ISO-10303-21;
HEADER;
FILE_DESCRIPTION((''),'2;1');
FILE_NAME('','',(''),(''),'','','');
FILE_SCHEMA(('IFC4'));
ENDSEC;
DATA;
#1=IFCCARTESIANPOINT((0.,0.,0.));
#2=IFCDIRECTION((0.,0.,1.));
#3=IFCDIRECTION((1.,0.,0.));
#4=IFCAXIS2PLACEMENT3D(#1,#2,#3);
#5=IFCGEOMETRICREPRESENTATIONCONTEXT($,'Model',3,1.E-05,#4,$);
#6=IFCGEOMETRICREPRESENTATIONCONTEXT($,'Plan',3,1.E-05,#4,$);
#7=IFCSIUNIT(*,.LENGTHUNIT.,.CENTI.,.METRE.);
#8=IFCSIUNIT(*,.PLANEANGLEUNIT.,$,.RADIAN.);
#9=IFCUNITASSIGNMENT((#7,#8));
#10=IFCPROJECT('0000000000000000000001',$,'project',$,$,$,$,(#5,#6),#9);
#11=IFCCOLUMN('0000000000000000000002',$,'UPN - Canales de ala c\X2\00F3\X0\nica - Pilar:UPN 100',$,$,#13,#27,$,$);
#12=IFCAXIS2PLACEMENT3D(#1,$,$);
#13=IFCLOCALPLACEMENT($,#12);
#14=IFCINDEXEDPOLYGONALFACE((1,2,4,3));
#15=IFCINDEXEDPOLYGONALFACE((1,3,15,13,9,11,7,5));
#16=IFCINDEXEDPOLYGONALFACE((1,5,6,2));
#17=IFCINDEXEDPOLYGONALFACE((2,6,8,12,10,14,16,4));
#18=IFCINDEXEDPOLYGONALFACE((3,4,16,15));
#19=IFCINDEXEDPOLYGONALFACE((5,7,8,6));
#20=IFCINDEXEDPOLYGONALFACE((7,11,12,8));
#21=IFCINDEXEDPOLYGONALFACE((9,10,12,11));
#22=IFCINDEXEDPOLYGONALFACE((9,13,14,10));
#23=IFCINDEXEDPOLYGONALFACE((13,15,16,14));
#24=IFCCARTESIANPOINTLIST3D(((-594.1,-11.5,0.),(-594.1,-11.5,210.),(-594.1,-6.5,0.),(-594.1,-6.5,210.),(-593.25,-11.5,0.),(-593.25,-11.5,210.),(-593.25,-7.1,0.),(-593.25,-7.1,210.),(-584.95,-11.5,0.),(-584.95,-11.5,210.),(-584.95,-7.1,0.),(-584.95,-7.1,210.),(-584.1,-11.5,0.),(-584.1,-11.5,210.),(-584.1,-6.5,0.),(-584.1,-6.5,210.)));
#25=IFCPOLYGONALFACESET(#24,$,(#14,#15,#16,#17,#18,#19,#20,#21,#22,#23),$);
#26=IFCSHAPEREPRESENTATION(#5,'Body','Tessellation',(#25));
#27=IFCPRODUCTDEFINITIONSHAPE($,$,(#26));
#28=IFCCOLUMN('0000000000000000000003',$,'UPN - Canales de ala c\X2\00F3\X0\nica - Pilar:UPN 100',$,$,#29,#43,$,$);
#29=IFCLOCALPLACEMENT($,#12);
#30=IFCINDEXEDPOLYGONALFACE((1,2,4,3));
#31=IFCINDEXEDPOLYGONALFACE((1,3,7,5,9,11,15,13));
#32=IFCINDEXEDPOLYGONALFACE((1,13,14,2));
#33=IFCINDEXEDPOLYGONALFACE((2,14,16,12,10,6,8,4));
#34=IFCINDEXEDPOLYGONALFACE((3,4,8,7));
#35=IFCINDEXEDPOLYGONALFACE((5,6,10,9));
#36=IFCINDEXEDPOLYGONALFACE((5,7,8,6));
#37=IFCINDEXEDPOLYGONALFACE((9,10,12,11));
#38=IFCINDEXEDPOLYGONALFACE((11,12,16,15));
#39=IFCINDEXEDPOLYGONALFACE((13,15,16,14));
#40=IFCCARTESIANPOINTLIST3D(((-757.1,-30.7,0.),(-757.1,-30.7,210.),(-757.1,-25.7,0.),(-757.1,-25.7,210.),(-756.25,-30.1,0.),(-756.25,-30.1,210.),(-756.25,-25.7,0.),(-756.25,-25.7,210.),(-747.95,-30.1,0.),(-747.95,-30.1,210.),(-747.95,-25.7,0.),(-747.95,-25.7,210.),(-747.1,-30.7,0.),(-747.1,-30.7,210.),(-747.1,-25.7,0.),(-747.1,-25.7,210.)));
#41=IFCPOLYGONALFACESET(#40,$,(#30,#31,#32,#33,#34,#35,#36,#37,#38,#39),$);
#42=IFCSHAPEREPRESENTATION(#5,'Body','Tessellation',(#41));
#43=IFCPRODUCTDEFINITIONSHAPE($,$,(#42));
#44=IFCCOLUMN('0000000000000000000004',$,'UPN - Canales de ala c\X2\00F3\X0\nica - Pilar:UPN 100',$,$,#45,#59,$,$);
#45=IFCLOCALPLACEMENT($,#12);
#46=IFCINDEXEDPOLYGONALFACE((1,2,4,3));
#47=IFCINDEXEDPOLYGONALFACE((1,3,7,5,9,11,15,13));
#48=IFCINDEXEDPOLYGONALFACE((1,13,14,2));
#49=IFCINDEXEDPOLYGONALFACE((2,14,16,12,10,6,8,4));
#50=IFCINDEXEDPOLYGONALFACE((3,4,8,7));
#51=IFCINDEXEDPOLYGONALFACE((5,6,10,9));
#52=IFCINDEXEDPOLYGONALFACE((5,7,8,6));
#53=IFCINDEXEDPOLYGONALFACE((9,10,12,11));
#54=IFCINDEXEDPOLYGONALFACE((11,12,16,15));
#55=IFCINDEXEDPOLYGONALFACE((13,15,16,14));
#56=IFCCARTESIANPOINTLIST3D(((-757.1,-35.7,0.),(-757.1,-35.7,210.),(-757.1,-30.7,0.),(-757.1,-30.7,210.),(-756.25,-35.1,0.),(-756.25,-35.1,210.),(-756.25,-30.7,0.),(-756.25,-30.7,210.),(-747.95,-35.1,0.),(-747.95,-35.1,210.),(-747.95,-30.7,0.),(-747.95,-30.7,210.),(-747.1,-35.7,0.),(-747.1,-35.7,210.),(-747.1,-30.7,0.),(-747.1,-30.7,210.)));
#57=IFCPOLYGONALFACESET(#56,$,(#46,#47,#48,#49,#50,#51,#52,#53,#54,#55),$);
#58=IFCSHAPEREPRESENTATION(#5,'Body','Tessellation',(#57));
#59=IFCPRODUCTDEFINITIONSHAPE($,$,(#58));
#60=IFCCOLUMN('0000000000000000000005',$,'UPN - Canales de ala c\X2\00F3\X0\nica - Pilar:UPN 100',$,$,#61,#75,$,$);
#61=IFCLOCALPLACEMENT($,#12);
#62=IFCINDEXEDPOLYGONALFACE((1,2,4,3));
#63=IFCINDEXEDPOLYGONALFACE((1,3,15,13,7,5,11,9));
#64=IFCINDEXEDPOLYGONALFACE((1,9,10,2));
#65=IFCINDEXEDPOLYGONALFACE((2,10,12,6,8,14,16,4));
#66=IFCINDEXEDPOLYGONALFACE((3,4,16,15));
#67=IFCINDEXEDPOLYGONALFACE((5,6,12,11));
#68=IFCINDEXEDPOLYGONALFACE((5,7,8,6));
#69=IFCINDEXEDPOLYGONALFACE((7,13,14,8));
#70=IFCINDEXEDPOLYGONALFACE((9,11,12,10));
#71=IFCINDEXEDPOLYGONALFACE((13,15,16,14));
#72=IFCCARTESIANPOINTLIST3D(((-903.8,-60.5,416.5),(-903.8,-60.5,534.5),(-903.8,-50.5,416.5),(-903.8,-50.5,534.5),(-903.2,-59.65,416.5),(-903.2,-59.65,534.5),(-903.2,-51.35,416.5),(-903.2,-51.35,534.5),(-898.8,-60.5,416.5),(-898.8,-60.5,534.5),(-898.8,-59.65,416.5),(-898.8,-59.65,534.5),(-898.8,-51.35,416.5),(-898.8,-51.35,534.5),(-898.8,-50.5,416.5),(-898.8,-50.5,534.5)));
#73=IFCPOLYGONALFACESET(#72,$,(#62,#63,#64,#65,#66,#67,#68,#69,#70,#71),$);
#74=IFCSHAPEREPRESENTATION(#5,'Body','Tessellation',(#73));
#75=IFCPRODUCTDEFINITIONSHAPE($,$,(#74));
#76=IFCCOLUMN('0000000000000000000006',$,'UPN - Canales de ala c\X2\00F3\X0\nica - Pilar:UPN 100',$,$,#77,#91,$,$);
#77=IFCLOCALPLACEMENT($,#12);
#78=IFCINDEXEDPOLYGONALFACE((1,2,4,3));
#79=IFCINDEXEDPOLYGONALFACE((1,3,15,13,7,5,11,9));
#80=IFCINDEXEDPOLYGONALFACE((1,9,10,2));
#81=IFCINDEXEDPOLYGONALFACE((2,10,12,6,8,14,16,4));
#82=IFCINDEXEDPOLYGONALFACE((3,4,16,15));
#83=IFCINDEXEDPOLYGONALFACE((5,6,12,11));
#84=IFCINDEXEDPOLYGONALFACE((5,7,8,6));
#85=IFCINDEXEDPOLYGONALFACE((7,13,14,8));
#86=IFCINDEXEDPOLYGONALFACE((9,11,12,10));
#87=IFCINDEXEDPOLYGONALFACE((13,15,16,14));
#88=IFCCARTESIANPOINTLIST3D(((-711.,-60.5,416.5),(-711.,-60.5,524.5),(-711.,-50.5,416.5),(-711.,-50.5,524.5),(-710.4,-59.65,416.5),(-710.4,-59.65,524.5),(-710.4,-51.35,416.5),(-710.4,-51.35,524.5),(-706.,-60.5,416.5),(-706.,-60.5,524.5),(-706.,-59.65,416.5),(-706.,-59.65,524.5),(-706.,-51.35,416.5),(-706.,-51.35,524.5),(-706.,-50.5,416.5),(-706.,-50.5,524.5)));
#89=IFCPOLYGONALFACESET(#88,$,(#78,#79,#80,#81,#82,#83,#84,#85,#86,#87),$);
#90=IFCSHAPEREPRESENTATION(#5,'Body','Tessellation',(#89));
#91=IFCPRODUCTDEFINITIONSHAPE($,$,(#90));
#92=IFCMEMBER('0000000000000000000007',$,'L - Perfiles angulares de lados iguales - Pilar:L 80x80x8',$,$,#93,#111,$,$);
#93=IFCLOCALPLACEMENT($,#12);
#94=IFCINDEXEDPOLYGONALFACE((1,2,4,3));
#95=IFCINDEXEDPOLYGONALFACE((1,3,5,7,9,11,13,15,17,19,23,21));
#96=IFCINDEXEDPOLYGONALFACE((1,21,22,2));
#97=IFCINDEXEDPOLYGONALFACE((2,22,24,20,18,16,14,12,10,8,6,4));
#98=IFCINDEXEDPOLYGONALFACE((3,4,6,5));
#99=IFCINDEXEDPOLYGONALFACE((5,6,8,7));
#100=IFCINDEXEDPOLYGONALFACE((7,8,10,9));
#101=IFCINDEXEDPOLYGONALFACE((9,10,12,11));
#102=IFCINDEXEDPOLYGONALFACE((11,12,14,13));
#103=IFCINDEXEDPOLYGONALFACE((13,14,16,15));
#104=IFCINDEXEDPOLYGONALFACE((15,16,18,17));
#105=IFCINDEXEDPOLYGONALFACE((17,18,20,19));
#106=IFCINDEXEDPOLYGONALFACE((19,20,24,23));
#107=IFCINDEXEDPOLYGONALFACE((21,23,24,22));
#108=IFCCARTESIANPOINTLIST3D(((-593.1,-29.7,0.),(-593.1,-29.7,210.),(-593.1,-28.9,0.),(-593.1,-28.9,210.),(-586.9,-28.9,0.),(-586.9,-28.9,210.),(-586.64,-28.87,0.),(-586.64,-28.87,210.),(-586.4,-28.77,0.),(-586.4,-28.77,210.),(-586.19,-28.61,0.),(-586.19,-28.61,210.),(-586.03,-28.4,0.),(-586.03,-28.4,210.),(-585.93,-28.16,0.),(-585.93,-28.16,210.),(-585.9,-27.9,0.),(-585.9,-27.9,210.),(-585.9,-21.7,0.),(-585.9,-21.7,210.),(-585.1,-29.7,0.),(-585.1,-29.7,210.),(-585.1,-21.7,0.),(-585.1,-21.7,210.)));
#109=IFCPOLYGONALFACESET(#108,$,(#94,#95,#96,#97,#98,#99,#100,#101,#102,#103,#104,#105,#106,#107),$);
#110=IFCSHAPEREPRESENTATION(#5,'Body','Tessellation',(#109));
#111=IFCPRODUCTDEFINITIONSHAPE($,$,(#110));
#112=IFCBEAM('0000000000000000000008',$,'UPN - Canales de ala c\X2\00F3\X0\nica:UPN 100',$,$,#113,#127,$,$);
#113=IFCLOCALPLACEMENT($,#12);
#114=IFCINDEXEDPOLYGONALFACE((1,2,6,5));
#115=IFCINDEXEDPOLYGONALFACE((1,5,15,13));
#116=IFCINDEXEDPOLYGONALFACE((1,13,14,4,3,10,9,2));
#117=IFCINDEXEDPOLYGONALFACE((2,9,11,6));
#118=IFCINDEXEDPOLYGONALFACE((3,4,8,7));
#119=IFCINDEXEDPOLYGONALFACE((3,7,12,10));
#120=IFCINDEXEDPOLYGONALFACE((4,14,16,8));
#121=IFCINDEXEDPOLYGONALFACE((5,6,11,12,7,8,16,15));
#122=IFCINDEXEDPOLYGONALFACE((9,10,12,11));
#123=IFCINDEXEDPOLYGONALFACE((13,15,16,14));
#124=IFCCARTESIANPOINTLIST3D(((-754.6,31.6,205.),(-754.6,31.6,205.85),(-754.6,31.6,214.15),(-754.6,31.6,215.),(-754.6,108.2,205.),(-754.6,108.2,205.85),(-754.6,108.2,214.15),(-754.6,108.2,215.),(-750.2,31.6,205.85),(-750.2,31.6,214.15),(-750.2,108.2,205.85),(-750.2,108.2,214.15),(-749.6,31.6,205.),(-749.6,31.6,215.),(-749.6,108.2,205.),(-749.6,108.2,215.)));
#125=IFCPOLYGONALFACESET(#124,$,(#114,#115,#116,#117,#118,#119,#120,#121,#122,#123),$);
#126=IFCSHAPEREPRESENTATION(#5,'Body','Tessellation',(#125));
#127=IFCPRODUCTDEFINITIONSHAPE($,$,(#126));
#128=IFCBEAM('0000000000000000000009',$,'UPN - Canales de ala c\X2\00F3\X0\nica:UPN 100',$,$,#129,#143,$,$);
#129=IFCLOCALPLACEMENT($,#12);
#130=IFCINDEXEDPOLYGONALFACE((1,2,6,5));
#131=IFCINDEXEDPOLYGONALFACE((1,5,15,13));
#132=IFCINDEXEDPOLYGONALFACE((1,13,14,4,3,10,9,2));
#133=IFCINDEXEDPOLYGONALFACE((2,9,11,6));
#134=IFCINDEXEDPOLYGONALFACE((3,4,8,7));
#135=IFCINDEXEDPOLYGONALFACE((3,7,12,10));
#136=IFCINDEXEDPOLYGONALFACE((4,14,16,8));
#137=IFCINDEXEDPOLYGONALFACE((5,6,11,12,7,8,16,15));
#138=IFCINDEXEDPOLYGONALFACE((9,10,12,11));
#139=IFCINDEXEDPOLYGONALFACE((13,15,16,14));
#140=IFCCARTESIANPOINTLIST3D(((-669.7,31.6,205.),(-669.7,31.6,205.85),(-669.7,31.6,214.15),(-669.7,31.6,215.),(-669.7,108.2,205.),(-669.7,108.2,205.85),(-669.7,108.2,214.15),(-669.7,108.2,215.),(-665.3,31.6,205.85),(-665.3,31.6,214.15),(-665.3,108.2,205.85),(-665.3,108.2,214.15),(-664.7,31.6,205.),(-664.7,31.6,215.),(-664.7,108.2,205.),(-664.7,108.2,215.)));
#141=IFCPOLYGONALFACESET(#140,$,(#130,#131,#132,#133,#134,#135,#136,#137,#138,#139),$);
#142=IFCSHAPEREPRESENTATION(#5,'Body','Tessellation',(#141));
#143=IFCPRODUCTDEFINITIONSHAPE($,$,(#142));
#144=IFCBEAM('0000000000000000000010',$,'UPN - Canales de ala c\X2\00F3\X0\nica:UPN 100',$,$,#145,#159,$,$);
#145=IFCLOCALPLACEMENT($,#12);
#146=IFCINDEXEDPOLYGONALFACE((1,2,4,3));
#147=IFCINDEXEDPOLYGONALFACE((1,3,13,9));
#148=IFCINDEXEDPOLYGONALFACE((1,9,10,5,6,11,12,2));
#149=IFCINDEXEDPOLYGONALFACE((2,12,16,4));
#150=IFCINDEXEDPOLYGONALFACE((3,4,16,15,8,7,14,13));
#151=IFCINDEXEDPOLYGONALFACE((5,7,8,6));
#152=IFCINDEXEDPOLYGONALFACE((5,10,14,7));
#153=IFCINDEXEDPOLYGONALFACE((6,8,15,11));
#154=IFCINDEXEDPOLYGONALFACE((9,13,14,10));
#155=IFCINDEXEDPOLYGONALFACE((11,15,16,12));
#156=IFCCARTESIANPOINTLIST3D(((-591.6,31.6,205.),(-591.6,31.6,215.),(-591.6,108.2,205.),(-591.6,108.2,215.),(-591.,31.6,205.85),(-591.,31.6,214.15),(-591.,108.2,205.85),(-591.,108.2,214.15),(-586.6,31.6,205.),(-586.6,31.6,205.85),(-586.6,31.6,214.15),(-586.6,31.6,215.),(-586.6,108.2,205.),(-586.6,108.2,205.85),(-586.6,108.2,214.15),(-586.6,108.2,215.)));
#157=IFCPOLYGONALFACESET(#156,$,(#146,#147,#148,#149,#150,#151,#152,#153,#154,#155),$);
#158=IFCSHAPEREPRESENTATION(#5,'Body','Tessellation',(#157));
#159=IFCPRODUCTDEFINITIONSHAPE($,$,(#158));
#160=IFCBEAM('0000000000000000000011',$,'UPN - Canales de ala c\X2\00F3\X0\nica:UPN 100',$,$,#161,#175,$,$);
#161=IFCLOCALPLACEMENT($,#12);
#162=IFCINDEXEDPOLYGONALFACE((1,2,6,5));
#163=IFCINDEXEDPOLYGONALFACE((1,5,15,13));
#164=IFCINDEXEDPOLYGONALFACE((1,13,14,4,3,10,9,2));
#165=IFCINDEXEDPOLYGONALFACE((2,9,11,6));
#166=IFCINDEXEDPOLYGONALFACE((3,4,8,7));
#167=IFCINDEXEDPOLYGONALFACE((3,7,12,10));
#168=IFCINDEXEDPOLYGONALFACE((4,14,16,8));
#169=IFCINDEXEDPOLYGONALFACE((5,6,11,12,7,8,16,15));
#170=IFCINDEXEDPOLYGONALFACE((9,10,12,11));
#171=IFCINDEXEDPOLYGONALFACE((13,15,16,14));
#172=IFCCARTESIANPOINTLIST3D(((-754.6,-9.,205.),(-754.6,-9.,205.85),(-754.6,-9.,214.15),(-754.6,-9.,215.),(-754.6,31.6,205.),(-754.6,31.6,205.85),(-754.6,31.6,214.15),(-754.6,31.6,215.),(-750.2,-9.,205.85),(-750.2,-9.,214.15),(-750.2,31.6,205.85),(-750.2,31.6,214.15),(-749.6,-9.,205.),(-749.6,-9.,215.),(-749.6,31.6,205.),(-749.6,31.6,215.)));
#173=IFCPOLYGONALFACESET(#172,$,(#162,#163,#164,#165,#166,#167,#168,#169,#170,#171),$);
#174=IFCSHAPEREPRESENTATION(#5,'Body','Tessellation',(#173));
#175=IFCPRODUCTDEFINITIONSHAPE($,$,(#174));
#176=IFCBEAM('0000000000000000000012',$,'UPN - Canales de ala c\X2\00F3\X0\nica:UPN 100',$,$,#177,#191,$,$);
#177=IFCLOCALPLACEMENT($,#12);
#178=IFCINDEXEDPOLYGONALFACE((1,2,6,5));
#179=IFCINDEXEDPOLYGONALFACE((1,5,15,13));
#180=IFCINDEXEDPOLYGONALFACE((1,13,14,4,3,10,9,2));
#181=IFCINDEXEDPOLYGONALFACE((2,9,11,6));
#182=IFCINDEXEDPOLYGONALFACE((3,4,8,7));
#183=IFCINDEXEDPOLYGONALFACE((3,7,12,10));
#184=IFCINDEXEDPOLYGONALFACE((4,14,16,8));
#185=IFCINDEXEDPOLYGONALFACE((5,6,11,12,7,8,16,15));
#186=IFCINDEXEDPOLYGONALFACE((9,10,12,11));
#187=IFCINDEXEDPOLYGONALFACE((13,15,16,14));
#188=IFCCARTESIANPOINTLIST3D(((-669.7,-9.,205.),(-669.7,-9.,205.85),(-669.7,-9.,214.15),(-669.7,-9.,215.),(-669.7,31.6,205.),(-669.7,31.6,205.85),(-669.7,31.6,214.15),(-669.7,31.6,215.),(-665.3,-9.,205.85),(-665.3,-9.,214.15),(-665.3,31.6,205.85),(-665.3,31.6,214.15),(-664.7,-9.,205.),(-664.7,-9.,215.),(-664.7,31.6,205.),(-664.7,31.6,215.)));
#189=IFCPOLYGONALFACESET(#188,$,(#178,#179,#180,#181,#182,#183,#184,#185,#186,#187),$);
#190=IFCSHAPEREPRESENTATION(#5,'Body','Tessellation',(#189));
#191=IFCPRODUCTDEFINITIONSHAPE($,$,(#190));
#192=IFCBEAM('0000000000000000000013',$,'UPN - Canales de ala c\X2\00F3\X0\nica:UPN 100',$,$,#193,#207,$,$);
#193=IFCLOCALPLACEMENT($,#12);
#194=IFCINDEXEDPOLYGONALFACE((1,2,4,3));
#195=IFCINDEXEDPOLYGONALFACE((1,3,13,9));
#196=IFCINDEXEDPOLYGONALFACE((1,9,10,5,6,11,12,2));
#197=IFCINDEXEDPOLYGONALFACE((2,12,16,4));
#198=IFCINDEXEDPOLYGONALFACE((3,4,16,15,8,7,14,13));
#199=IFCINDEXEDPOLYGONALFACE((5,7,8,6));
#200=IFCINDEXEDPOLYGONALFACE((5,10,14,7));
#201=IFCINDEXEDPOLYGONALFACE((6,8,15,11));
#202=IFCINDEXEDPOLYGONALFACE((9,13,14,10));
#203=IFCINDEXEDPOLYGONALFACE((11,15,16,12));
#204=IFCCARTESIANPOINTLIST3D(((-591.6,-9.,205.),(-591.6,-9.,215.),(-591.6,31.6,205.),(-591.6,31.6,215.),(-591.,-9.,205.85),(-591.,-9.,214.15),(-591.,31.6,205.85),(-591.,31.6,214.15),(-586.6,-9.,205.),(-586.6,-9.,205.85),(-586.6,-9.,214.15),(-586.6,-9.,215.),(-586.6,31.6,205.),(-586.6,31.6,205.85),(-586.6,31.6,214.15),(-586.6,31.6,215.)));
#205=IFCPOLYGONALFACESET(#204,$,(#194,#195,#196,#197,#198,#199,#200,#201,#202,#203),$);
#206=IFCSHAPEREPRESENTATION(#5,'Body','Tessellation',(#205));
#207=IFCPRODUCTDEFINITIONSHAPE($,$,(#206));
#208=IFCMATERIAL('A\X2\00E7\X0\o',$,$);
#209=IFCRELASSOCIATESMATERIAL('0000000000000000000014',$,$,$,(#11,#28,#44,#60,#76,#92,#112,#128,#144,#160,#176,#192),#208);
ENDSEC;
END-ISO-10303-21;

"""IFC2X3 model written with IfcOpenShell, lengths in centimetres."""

from ifc_helpers import new_model, si_unit, frame, frame_2d, origin_with_axes, origin_2d_with_axis, place, context, project, l_section, u_section, extrude, material, element, save


model = new_model("IFC2X3")

# Units and contexts
model_context = context("Model", 3, precision=1e-05, world=origin_with_axes())
plan_context = context("Plan", 3, precision=1e-05, world=origin_with_axes())
ifc_project = project(units=[si_unit("LENGTHUNIT", "METRE", prefix="CENTI"), si_unit("PLANEANGLEUNIT", "RADIAN")], contexts=[model_context, plan_context])

# Columns
ifc_material = material(Name="Aço")
column_1_placement = place(None, frame((-589.1, -9.0, 0.0), z_axis=(0.0, 0.0, 1.0), x_axis=(0.0, -1.0, 0.0)))
element("IfcColumn", 1, at=column_1_placement, material=ifc_material, Name="UPN - Canales de ala cónica - Pilar:UPN 100", context=model_context, shape_type="SweptSolid", body=[
    extrude(u_section(Depth=10.0, FlangeWidth=5.0, WebThickness=0.6, FlangeThickness=0.85, FilletRadius=0.0, EdgeRadius=0.0, FlangeSlope=0.0, CentreOfGravityInX=0.0, at=frame_2d((0.0, 0.0), x_axis=(1.0, 0.0))), origin_with_axes(), (0.0, 0.0, 1.0), 210.0),
])
for number, where, z_axis, x_axis, name in (
    (2, (-752.1, -28.2, 0.0), (0.0, 0.0, 1.0), (0.0, 1.0, 0.0), "UPN - Canales de ala cónica - Pilar:UPN 100"),
    (3, (-752.1, -33.2, 0.0), (0.0, 0.0, 1.0), (0.0, 1.0, 0.0), "UPN - Canales de ala cónica - Pilar:UPN 100"),
):
    element("IfcColumn", number, at=place(None, frame(where, z_axis=z_axis, x_axis=x_axis)), material=ifc_material, Name=name, context=model_context, shape_type="SweptSolid", body=[
        extrude(u_section(Depth=10.0, FlangeWidth=5.0, WebThickness=0.6, FlangeThickness=0.85, FilletRadius=0.0, EdgeRadius=0.0, FlangeSlope=0.0, CentreOfGravityInX=0.0, at=origin_2d_with_axis()), origin_with_axes(), (0.0, 0.0, 1.0), 210.0),
    ])
column_2_placement = place(None, frame((-901.3, -55.5, 416.5), z_axis=(0.0, 0.0, 1.0), x_axis=(1.0, 0.0, 0.0)))
element("IfcColumn", 4, at=column_2_placement, material=ifc_material, Name="UPN - Canales de ala cónica - Pilar:UPN 100", context=model_context, shape_type="SweptSolid", body=[
    extrude(u_section(Depth=10.0, FlangeWidth=5.0, WebThickness=0.6, FlangeThickness=0.85, FilletRadius=0.0, EdgeRadius=0.0, FlangeSlope=0.0, CentreOfGravityInX=0.0, at=origin_2d_with_axis()), origin_with_axes(), (0.0, 0.0, 1.0), 118.0),
])
column_3_placement = place(None, frame((-708.5, -55.5, 416.5), z_axis=(0.0, 0.0, 1.0), x_axis=(1.0, 0.0, 0.0)))
element("IfcColumn", 5, at=column_3_placement, material=ifc_material, Name="UPN - Canales de ala cónica - Pilar:UPN 100", context=model_context, shape_type="SweptSolid", body=[
    extrude(u_section(Depth=10.0, FlangeWidth=5.0, WebThickness=0.6, FlangeThickness=0.85, FilletRadius=0.0, EdgeRadius=0.0, FlangeSlope=0.0, CentreOfGravityInX=0.0, at=origin_2d_with_axis()), origin_with_axes(), (0.0, 0.0, 1.0), 108.0),
])

# Member
member_placement = place(None, frame((-589.1, -25.7, 0.0), z_axis=(0.0, 0.0, 1.0), x_axis=(0.0, 1.0, 0.0)))
element("IfcMember", 6, at=member_placement, material=ifc_material, Name="L - Perfiles angulares de lados iguales - Pilar:L 80x80x8", context=model_context, shape_type="SweptSolid", body=[
    extrude(l_section(Depth=8.0, Width=8.0, Thickness=0.8, FilletRadius=1.0, EdgeRadius=0.0, LegSlope=0.0, CentreOfGravityInX=0.0, CentreOfGravityInY=0.0, at=origin_2d_with_axis()), origin_with_axes(), (0.0, 0.0, 1.0), 210.0),
])

# Beams
for number, where, z_axis, x_axis, name in (
    (7, (-752.1, 31.6, 210.0), (0.0, 1.0, 0.0), (-1.0, 0.0, 0.0), "UPN - Canales de ala cónica:UPN 100"),
    (8, (-667.2, 31.6, 210.0), (0.0, 1.0, 0.0), (-1.0, 0.0, 0.0), "UPN - Canales de ala cónica:UPN 100"),
    (9, (-589.1, 31.6, 210.0), (0.0, 1.0, 0.0), (1.0, 0.0, 0.0), "UPN - Canales de ala cónica:UPN 100"),
):
    element("IfcBeam", number, at=place(None, frame(where, z_axis=z_axis, x_axis=x_axis)), material=ifc_material, Name=name, context=model_context, shape_type="SweptSolid", body=[
        extrude(u_section(Depth=10.0, FlangeWidth=5.0, WebThickness=0.6, FlangeThickness=0.85, FilletRadius=0.0, EdgeRadius=0.0, FlangeSlope=0.0, CentreOfGravityInX=0.0, at=origin_2d_with_axis()), origin_with_axes(), (0.0, 0.0, 1.0), 76.6),
    ])
for number, where, z_axis, x_axis, name in (
    (10, (-752.1, -9.0, 210.0), (0.0, 1.0, 0.0), (-1.0, 0.0, 0.0), "UPN - Canales de ala cónica:UPN 100"),
    (11, (-667.2, -9.0, 210.0), (0.0, 1.0, 0.0), (-1.0, 0.0, 0.0), "UPN - Canales de ala cónica:UPN 100"),
    (12, (-589.1, -9.0, 210.0), (0.0, 1.0, 0.0), (1.0, 0.0, 0.0), "UPN - Canales de ala cónica:UPN 100"),
):
    element("IfcBeam", number, at=place(None, frame(where, z_axis=z_axis, x_axis=x_axis)), material=ifc_material, Name=name, context=model_context, shape_type="SweptSolid", body=[
        extrude(u_section(Depth=10.0, FlangeWidth=5.0, WebThickness=0.6, FlangeThickness=0.85, FilletRadius=0.0, EdgeRadius=0.0, FlangeSlope=0.0, CentreOfGravityInX=0.0, at=origin_2d_with_axis()), origin_with_axes(), (0.0, 0.0, 1.0), 40.6),
    ])

save(model, "model.ifc")
